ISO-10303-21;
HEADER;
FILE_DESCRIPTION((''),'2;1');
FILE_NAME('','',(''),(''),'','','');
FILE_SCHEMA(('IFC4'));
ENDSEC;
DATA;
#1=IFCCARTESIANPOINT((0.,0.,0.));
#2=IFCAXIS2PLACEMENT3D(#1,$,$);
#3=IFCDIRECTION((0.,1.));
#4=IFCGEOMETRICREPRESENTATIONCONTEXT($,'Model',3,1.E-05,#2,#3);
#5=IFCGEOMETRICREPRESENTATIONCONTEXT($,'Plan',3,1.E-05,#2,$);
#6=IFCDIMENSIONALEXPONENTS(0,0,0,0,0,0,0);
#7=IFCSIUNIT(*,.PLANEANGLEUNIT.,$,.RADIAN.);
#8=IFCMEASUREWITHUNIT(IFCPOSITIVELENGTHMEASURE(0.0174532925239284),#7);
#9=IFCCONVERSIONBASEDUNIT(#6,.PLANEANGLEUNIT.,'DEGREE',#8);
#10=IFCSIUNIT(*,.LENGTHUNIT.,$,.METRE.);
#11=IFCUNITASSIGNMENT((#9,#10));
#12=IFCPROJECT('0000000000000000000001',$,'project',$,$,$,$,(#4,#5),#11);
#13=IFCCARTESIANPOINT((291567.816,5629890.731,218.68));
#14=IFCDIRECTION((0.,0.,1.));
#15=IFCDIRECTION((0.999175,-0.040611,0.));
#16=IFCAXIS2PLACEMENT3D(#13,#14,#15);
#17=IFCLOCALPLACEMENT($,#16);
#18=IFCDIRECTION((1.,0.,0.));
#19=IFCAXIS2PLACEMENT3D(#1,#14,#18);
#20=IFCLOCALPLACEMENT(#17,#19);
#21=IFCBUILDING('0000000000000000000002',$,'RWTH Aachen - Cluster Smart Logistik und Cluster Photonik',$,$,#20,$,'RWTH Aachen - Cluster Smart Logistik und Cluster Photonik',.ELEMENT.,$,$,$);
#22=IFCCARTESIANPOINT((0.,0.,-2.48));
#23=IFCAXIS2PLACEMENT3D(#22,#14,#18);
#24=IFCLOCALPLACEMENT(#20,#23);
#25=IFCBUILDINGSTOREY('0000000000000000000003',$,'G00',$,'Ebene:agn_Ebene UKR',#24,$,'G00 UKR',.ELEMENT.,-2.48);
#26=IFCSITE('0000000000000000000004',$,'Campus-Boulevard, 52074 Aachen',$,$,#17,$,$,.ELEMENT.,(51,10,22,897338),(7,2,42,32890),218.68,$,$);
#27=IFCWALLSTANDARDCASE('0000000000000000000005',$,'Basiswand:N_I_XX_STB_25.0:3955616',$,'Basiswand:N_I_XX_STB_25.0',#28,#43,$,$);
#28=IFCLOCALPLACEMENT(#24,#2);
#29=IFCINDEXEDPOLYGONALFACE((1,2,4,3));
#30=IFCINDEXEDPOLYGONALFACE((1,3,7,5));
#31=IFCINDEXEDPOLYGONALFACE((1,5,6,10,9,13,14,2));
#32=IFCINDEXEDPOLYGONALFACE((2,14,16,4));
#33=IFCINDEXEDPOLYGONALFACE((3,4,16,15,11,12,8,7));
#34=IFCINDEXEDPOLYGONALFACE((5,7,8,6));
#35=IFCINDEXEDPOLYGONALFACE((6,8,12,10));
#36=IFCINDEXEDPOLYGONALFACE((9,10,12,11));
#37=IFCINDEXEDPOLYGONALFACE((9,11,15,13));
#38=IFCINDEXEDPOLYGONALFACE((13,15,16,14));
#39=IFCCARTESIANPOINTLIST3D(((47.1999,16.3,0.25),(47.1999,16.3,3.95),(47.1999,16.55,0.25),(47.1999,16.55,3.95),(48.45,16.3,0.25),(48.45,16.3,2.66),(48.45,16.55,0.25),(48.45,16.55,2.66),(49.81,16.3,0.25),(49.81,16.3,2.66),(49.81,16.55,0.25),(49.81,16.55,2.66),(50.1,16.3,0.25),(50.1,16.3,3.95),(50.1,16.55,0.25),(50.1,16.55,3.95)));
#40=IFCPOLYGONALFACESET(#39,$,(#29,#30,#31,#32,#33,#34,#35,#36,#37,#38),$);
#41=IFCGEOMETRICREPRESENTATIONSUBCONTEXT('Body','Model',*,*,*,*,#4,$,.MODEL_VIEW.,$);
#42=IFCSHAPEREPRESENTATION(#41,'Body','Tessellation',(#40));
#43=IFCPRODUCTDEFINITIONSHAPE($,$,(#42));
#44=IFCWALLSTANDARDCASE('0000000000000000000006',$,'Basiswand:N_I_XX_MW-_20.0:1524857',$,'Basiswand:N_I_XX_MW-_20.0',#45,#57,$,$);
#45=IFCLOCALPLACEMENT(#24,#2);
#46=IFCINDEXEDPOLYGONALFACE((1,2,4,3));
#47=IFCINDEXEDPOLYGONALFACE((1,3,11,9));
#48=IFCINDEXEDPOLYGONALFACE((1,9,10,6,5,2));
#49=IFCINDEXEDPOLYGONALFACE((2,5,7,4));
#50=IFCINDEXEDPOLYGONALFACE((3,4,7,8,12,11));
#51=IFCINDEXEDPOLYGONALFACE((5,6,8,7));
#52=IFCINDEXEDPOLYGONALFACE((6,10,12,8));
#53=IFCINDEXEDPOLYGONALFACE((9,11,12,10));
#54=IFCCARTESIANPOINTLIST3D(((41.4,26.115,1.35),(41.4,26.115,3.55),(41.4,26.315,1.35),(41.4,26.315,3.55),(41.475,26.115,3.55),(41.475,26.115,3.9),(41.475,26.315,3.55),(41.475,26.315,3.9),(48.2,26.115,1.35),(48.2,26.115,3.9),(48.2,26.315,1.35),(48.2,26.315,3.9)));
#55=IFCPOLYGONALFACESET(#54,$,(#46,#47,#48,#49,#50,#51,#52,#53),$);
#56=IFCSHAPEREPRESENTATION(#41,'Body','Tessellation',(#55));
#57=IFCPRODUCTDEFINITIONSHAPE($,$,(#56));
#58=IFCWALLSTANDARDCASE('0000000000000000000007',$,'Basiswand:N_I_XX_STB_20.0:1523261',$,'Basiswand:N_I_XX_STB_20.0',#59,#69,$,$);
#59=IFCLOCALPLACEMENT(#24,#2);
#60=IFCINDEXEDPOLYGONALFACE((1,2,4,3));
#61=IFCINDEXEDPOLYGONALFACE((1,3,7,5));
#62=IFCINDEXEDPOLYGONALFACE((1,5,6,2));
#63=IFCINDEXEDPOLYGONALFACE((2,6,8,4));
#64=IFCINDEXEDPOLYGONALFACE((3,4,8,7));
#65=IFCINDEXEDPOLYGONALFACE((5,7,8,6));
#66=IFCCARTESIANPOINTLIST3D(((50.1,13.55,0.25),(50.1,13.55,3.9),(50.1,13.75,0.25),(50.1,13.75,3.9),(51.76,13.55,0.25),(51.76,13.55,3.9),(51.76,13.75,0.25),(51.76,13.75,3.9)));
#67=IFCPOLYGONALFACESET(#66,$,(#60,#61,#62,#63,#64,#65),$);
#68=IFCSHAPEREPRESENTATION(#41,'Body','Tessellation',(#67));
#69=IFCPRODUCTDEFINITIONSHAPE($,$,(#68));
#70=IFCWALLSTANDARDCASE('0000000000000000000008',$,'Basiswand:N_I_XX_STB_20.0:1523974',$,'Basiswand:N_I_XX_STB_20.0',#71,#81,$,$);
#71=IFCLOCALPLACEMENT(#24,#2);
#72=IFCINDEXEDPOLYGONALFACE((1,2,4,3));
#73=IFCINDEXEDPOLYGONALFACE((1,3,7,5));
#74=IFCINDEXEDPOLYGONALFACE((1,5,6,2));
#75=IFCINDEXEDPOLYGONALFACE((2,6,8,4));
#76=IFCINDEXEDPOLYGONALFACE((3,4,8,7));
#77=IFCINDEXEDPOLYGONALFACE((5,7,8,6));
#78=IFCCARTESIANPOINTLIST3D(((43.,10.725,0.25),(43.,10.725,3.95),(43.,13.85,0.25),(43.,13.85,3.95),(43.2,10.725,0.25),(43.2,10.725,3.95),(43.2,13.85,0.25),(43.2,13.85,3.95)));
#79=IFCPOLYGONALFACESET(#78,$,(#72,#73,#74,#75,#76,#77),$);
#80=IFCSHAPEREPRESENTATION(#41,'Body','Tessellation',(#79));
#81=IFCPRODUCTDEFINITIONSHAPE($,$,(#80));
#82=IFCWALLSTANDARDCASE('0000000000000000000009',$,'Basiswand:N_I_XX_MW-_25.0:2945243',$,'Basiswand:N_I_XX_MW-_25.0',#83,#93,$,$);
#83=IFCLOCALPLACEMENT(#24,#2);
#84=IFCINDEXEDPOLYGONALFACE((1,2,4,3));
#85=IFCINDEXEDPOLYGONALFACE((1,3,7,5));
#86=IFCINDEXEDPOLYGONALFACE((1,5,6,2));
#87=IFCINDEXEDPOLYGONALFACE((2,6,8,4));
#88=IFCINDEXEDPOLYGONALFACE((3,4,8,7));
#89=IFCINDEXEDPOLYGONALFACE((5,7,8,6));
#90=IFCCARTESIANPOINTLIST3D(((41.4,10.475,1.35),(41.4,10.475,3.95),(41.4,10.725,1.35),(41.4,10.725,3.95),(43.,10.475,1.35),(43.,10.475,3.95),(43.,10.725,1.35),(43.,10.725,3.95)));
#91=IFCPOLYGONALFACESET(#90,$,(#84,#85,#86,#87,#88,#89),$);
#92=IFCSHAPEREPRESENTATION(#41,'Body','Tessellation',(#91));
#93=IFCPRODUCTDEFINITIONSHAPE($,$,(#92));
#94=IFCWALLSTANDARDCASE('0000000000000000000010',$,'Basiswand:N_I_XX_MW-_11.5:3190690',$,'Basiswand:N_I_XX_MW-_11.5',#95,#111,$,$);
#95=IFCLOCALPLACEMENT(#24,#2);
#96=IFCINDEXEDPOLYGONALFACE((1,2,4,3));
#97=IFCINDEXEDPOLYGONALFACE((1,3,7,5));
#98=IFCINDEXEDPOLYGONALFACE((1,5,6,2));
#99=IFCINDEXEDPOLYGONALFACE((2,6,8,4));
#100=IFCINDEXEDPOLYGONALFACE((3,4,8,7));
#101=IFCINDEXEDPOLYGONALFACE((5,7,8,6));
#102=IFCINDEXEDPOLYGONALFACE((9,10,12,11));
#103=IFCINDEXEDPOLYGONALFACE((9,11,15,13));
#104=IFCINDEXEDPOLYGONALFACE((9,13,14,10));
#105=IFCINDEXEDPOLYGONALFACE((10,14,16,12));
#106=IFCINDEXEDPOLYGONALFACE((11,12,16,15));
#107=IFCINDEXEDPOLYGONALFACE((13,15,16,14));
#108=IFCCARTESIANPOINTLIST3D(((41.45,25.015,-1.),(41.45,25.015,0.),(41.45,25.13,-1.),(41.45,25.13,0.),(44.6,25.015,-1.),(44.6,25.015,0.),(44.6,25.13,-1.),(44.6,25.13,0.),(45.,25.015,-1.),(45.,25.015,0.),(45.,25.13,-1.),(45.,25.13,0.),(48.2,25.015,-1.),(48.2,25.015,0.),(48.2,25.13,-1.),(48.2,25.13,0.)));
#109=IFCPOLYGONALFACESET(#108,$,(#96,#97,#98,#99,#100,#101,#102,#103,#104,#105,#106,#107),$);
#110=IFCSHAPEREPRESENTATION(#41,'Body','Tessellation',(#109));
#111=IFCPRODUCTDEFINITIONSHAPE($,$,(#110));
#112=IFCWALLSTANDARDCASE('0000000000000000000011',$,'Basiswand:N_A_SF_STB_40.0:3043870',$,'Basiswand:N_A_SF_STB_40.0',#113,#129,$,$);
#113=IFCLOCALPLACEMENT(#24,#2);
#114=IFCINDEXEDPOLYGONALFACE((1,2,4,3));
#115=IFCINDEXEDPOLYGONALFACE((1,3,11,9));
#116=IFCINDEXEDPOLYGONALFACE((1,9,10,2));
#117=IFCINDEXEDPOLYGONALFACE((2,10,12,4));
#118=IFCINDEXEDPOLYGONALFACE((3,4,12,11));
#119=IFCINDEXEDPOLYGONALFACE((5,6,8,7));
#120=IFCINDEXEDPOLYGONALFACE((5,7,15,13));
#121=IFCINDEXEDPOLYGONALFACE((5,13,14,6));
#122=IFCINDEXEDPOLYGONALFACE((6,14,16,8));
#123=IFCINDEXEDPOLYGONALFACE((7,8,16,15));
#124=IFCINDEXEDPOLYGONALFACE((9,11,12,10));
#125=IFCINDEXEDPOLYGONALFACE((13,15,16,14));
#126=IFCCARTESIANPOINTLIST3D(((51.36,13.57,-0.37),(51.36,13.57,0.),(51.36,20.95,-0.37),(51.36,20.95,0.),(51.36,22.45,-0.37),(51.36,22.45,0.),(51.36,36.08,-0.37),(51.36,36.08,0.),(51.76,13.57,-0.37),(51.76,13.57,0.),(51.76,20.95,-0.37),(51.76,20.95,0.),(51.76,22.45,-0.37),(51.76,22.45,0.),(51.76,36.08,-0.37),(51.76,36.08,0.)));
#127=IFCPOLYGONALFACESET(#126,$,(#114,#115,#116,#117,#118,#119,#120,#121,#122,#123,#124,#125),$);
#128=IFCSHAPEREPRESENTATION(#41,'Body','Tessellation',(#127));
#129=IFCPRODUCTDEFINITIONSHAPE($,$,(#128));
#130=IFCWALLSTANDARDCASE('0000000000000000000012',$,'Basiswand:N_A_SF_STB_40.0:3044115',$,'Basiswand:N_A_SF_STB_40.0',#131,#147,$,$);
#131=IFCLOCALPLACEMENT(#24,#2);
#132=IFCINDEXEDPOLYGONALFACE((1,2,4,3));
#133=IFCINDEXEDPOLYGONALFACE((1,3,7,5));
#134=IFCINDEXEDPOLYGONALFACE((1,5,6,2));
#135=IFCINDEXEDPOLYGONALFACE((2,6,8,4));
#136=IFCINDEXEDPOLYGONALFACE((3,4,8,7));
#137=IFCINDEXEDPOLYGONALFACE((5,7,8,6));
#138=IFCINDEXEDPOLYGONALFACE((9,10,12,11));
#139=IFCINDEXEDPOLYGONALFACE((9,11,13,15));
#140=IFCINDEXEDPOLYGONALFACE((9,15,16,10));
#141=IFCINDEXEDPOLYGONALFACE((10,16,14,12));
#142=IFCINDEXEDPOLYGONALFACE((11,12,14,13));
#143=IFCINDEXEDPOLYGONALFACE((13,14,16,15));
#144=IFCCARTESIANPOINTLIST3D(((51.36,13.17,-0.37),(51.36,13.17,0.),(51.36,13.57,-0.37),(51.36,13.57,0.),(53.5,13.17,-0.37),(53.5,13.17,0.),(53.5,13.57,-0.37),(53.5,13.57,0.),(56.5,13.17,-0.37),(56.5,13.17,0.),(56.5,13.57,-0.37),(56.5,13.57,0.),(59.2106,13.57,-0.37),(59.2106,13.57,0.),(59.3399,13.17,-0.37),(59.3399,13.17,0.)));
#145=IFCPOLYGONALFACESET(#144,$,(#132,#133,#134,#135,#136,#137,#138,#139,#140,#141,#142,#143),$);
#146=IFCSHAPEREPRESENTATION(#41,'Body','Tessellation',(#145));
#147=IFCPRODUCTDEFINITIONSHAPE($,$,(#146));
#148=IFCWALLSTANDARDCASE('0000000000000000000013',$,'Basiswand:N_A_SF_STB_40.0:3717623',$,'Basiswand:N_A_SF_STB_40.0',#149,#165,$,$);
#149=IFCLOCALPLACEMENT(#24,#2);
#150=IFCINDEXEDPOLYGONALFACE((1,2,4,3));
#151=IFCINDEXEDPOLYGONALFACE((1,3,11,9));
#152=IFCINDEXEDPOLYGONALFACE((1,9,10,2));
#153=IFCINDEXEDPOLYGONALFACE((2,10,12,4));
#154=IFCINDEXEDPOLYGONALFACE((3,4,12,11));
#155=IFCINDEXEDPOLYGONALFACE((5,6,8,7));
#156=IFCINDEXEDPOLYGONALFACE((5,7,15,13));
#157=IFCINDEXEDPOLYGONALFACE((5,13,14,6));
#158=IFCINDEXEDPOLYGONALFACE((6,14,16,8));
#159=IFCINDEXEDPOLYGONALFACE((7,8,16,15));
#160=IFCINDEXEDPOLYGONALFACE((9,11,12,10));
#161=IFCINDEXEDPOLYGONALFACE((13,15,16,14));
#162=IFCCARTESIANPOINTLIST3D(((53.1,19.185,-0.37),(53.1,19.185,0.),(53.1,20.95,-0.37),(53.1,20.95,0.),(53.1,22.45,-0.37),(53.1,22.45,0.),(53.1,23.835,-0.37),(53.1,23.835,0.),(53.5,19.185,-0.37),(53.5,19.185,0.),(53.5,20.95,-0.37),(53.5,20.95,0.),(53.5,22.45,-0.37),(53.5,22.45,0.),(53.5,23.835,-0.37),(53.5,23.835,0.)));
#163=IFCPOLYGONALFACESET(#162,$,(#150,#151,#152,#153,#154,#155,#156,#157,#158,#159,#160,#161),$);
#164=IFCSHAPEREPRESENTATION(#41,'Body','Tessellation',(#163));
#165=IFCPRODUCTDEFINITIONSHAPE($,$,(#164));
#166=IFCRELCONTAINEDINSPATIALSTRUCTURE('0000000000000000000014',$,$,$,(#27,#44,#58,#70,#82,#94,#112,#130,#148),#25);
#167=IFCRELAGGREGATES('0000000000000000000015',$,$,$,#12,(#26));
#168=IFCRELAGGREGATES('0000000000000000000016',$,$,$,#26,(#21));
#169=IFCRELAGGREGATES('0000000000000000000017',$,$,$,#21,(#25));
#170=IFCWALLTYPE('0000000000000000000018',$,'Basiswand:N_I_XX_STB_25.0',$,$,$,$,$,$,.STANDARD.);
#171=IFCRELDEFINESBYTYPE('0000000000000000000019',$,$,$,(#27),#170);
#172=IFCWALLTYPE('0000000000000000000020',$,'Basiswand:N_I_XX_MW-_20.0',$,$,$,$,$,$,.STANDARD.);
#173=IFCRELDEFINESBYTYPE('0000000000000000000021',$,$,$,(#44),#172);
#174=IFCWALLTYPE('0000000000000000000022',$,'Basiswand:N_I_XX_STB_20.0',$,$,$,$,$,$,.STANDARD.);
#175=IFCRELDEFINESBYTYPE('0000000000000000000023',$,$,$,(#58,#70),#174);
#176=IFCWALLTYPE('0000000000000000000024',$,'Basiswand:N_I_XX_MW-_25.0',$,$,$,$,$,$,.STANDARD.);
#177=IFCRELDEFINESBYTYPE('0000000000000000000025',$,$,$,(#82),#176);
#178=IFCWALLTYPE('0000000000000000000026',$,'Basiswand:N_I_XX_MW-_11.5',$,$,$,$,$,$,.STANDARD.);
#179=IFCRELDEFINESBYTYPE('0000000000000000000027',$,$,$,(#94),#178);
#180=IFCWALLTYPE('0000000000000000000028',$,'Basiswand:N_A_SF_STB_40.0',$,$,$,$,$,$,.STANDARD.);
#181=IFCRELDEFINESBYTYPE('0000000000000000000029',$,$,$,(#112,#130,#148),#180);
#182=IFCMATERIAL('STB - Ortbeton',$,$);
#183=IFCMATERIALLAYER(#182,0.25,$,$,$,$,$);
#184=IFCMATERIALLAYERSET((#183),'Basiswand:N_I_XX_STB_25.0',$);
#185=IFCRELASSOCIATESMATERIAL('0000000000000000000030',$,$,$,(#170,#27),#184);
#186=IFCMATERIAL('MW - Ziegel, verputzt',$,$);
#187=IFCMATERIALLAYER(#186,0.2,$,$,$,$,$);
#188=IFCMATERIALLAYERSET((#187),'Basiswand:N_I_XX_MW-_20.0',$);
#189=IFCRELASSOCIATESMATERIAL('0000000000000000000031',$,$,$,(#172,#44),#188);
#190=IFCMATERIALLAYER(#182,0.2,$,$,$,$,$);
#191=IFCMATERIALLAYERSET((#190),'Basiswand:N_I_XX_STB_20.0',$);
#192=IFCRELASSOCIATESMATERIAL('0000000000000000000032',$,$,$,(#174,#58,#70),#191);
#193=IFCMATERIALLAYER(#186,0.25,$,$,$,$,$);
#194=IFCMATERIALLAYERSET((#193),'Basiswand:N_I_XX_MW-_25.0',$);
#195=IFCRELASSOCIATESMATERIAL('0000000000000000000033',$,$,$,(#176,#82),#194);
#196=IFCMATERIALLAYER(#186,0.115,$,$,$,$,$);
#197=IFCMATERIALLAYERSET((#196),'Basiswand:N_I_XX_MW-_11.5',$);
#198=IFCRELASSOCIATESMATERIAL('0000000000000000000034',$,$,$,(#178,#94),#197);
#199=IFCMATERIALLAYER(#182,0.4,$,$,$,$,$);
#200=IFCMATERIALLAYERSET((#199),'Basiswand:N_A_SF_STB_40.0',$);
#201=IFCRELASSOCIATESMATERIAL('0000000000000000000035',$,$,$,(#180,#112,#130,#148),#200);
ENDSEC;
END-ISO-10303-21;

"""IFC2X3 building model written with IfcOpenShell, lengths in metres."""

from ifc_helpers import new_model, entity, si_unit, converted_unit, direction, frame, frame_2d, origin, origin_with_axes, origin_2d_with_axis, place, context, subcontext, project, spatial, polyline, rectangle, extrude, clip, bounded_halfspace, material, layer, layer_set, layer_usage, type_object, element, save


model = new_model("IFC2X3")

# Units and contexts
model_context = context("Model", 3, precision=1e-05, world=origin(), true_north=direction((0.0, 1.0)))
plan_context = context("Plan", 3, precision=1e-05, world=origin())
body_context = subcontext(model_context, "Body", "Model", "MODEL_VIEW")
ifc_project = project(units=[converted_unit("PLANEANGLEUNIT", "DEGREE", entity("IfcPositiveLengthMeasure", 0.0174532925239284), si_unit("PLANEANGLEUNIT", "RADIAN"), dimensions=[0, 0, 0, 0, 0, 0, 0]), si_unit("LENGTHUNIT", "METRE")], contexts=[model_context, plan_context])

# Site, building, storey
site_placement = place(None, frame((291567.816, 5629890.731, 218.68), z_axis=(0.0, 0.0, 1.0), x_axis=(0.999175, -0.040611, 0.0)))
site = spatial("IfcSite", under=ifc_project, at=site_placement, Name="Campus-Boulevard, 52074 Aachen", CompositionType="ELEMENT", RefLatitude=(51, 10, 22, 897338), RefLongitude=(7, 2, 42, 32890), RefElevation=218.68)
building_placement = place(site_placement, origin_with_axes())
building = spatial("IfcBuilding", under=site, at=building_placement, Name="RWTH Aachen - Cluster Smart Logistik und Cluster Photonik", LongName="RWTH Aachen - Cluster Smart Logistik und Cluster Photonik", CompositionType="ELEMENT")
storey_placement = place(building_placement, frame((0.0, 0.0, -2.48), z_axis=(0.0, 0.0, 1.0), x_axis=(1.0, 0.0, 0.0)))
storey = spatial("IfcBuildingStorey", under=building, at=storey_placement, Name="G00", ObjectType="Ebene:agn_Ebene UKR", LongName="G00 UKR", CompositionType="ELEMENT", Elevation=-2.48)

# Shared definitions
ifc_material_1 = material(Name="STB - Ortbeton")

# Shared definitions
ifc_layer_1 = layer(ifc_material_1, 0.25)
ifc_layer_set_1 = layer_set([ifc_layer_1], Name="Basiswand:N_I_XX_STB_25.0")
wall_type_1 = type_object("IfcWallType", Name="Basiswand:N_I_XX_STB_25.0", PredefinedType="STANDARD", material=ifc_layer_set_1)

# Wall, opening
ifc_layer_usage_1 = layer_usage(ifc_layer_set_1, "AXIS2", "NEGATIVE", 0.125)
wall_1_placement = place(storey_placement, frame((50.1, 16.425, 0.25), z_axis=(0.0, 0.0, 1.0), x_axis=(-1.0, 0.0, 0.0)))
wall_1 = element("IfcWallStandardCase", 1, at=wall_1_placement, inside=storey, type_object=wall_type_1, material=ifc_layer_usage_1, Name="Basiswand:N_I_XX_STB_25.0:3955616", ObjectType="Basiswand:N_I_XX_STB_25.0", context=body_context, shape_type="SweptSolid", body=[
    extrude(rectangle(XDim=2.9002, YDim=0.25, at=frame_2d((1.4501, 0.0), x_axis=(-1.0, 0.0))), origin(), (0.0, 0.0, 1.0), 3.7),
])
opening_1_placement = place(wall_1_placement, frame((0.29, -0.125, 0.0), z_axis=(0.0, 0.0, 1.0), x_axis=(1.0, 0.0, 0.0)))
element("IfcOpeningElement", 2, at=opening_1_placement, cuts=wall_1, ObjectType="Opening", context=body_context, shape_type="SweptSolid", body=[
    extrude(rectangle(XDim=2.41, YDim=1.36, at=frame_2d((1.205, 0.68), x_axis=(1.0, 0.0))), frame((0.0, 0.0, 0.0), z_axis=(0.0, 1.0, 0.0), x_axis=(0.0, 0.0, 1.0)), (0.0, 0.0, 1.0), 0.25),
])

# Walls
ifc_material_2 = material(Name="MW - Ziegel, verputzt")
ifc_layer_2 = layer(ifc_material_2, 0.2)
ifc_layer_set_2 = layer_set([ifc_layer_2], Name="Basiswand:N_I_XX_MW-_20.0")
ifc_layer_usage_2 = layer_usage(ifc_layer_set_2, "AXIS2", "NEGATIVE", 0.1)
wall_type_2 = type_object("IfcWallType", Name="Basiswand:N_I_XX_MW-_20.0", PredefinedType="STANDARD", material=ifc_layer_set_2)
wall_2_placement = place(storey_placement, frame((41.4, 26.215, 1.35), z_axis=(0.0, 0.0, 1.0), x_axis=(1.0, 0.0, 0.0)))
element("IfcWallStandardCase", 3, at=wall_2_placement, inside=storey, type_object=wall_type_2, material=ifc_layer_usage_2, Name="Basiswand:N_I_XX_MW-_20.0:1524857", ObjectType="Basiswand:N_I_XX_MW-_20.0", context=body_context, shape_type="Clipping", body=[
    clip(clip(extrude(rectangle(XDim=6.8, YDim=0.2, at=frame_2d((3.4, 0.0), x_axis=(-1.0, 0.0))), origin(), (0.0, 0.0, 1.0), 2.55), bounded_halfspace(frame((0.075, 0.1, 2.2), z_axis=(-1.0, 0.0, 0.0), x_axis=(0.0, 0.0, -1.0)), False, frame((0.075, 0.1, 2.2), z_axis=(-1.0, 0.0, 0.0), x_axis=(0.0, 0.0, -1.0)), polyline([(0.0, 0.0), (0.0, 0.2), (-0.35, 0.2), (-0.35, 0.0), (0.0, 0.0)]))), bounded_halfspace(frame((0.075, -0.1, 2.2), z_axis=(0.0, 0.0, 1.0), x_axis=(-1.0, 0.0, 0.0)), False, frame((0.075, -0.1, 2.2), z_axis=(0.0, 0.0, 1.0), x_axis=(-1.0, 0.0, 0.0)), polyline([(0.0, 0.0), (0.0, -0.2), (0.075, -0.2), (0.075, 0.0), (0.0, 0.0)]))),
])
ifc_layer_3 = layer(ifc_material_1, 0.2)
ifc_layer_set_3 = layer_set([ifc_layer_3], Name="Basiswand:N_I_XX_STB_20.0")
ifc_layer_usage_3 = layer_usage(ifc_layer_set_3, "AXIS2", "NEGATIVE", 0.1)
wall_type_3 = type_object("IfcWallType", Name="Basiswand:N_I_XX_STB_20.0", PredefinedType="STANDARD", material=ifc_layer_set_3)
wall_3_placement = place(storey_placement, frame((51.76, 13.65, 0.25), z_axis=(0.0, 0.0, 1.0), x_axis=(-1.0, 0.0, 0.0)))
element("IfcWallStandardCase", 4, at=wall_3_placement, inside=storey, type_object=wall_type_3, material=ifc_layer_usage_3, Name="Basiswand:N_I_XX_STB_20.0:1523261", ObjectType="Basiswand:N_I_XX_STB_20.0", context=body_context, shape_type="SweptSolid", body=[
    extrude(rectangle(XDim=1.66, YDim=0.2, at=frame_2d((0.83, 0.0), x_axis=(-1.0, 0.0))), origin(), (0.0, 0.0, 1.0), 3.65),
])
ifc_layer_usage_4 = layer_usage(ifc_layer_set_3, "AXIS2", "NEGATIVE", 0.1)
wall_4_placement = place(storey_placement, frame((43.1, 13.85, 0.25), z_axis=(0.0, 0.0, 1.0), x_axis=(0.0, -1.0, 0.0)))
element("IfcWallStandardCase", 5, at=wall_4_placement, inside=storey, type_object=wall_type_3, material=ifc_layer_usage_4, Name="Basiswand:N_I_XX_STB_20.0:1523974", ObjectType="Basiswand:N_I_XX_STB_20.0", context=body_context, shape_type="SweptSolid", body=[
    extrude(rectangle(XDim=3.125, YDim=0.2, at=frame_2d((1.5625, 0.0), x_axis=(-1.0, 0.0))), origin(), (0.0, 0.0, 1.0), 3.7),
])
ifc_layer_4 = layer(ifc_material_2, 0.25)
ifc_layer_set_4 = layer_set([ifc_layer_4], Name="Basiswand:N_I_XX_MW-_25.0")
ifc_layer_usage_5 = layer_usage(ifc_layer_set_4, "AXIS2", "NEGATIVE", 0.125)
wall_type_4 = type_object("IfcWallType", Name="Basiswand:N_I_XX_MW-_25.0", PredefinedType="STANDARD", material=ifc_layer_set_4)
wall_5_placement = place(storey_placement, frame((43.0, 10.6, 1.35), z_axis=(0.0, 0.0, 1.0), x_axis=(-1.0, 0.0, 0.0)))
element("IfcWallStandardCase", 6, at=wall_5_placement, inside=storey, type_object=wall_type_4, material=ifc_layer_usage_5, Name="Basiswand:N_I_XX_MW-_25.0:2945243", ObjectType="Basiswand:N_I_XX_MW-_25.0", context=body_context, shape_type="SweptSolid", body=[
    extrude(rectangle(XDim=1.6, YDim=0.25, at=frame_2d((0.8, 0.0), x_axis=(-1.0, 0.0))), origin(), (0.0, 0.0, 1.0), 2.6),
])

# Walls, openings
ifc_layer_5 = layer(ifc_material_2, 0.115)
ifc_layer_set_5 = layer_set([ifc_layer_5], Name="Basiswand:N_I_XX_MW-_11.5")
ifc_layer_usage_6 = layer_usage(ifc_layer_set_5, "AXIS2", "NEGATIVE", 0.0575)
wall_type_5 = type_object("IfcWallType", Name="Basiswand:N_I_XX_MW-_11.5", PredefinedType="STANDARD", material=ifc_layer_set_5)
wall_6_placement = place(storey_placement, frame((48.2, 25.0725, -1.0), z_axis=(0.0, 0.0, 1.0), x_axis=(-1.0, 0.0, 0.0)))
wall_6 = element("IfcWallStandardCase", 7, at=wall_6_placement, inside=storey, type_object=wall_type_5, material=ifc_layer_usage_6, Name="Basiswand:N_I_XX_MW-_11.5:3190690", ObjectType="Basiswand:N_I_XX_MW-_11.5", context=body_context, shape_type="SweptSolid", body=[
    extrude(rectangle(XDim=6.75, YDim=0.115, at=frame_2d((3.375, 0.0), x_axis=(-1.0, 0.0))), origin(), (0.0, 0.0, 1.0), 1.0),
])
opening_2_placement = place(wall_6_placement, origin_with_axes())
element("IfcOpeningElement", 8, at=opening_2_placement, cuts=wall_6, ObjectType="Opening", context=body_context, shape_type="SweptSolid", body=[
    extrude(rectangle(XDim=1.0, YDim=0.115, at=origin_2d_with_axis()), frame((3.6, 0.0, 0.5), z_axis=(-1.0, 0.0, 0.0), x_axis=(0.0, 0.0, 1.0)), (0.0, 0.0, 1.0), 0.4),
])
ifc_layer_6 = layer(ifc_material_1, 0.4)
ifc_layer_set_6 = layer_set([ifc_layer_6], Name="Basiswand:N_A_SF_STB_40.0")
ifc_layer_usage_7 = layer_usage(ifc_layer_set_6, "AXIS2", "POSITIVE", -0.2)
wall_type_6 = type_object("IfcWallType", Name="Basiswand:N_A_SF_STB_40.0", PredefinedType="STANDARD", material=ifc_layer_set_6)
wall_7_placement = place(storey_placement, frame((51.56, 13.57, -0.37), z_axis=(0.0, 0.0, 1.0), x_axis=(0.0, 1.0, 0.0)))
wall_7 = element("IfcWallStandardCase", 9, at=wall_7_placement, inside=storey, type_object=wall_type_6, material=ifc_layer_usage_7, Name="Basiswand:N_A_SF_STB_40.0:3043870", ObjectType="Basiswand:N_A_SF_STB_40.0", context=body_context, shape_type="SweptSolid", body=[
    extrude(rectangle(XDim=22.51, YDim=0.4, at=frame_2d((11.255, 0.0), x_axis=(-1.0, 0.0))), origin(), (0.0, 0.0, 1.0), 0.37),
])
opening_3_placement = place(wall_7_placement, origin_with_axes())
element("IfcOpeningElement", 10, at=opening_3_placement, cuts=wall_7, ObjectType="Opening", context=body_context, shape_type="SweptSolid", body=[
    extrude(rectangle(XDim=0.37, YDim=0.4, at=frame_2d((0.005, -0.04), x_axis=(1.0, 0.0))), frame((7.38, 0.04, 0.19), z_axis=(1.0, 0.0, 0.0), x_axis=(0.0, 0.0, -1.0)), (0.0, 0.0, 1.0), 1.5),
])
ifc_layer_usage_8 = layer_usage(ifc_layer_set_6, "AXIS2", "POSITIVE", -0.2)
wall_8_placement = place(storey_placement, frame((59.3399, 13.37, -0.37), z_axis=(0.0, 0.0, 1.0), x_axis=(-1.0, 0.0, 0.0)))
wall_8 = element("IfcWallStandardCase", 11, at=wall_8_placement, inside=storey, type_object=wall_type_6, material=ifc_layer_usage_8, Name="Basiswand:N_A_SF_STB_40.0:3044115", ObjectType="Basiswand:N_A_SF_STB_40.0", context=body_context, shape_type="Clipping", body=[
    clip(extrude(rectangle(XDim=7.9799, YDim=0.4, at=frame_2d((3.9899, 0.0), x_axis=(-1.0, 0.0))), origin(), (0.0, 0.0, 1.0), 0.37), bounded_halfspace(frame((0.1293, -0.2, 0.37), z_axis=(0.95152, 0.307586, 0.0), x_axis=(0.0, 0.0, -1.0)), True, frame((0.1293, -0.2, 0.37), z_axis=(0.95152, 0.307586, 0.0), x_axis=(0.0, 0.0, -1.0)), polyline([(0.0, 0.0), (0.37, 0.0), (0.37, 0.4204), (0.16, 0.4204), (0.0, 0.4204), (0.0, 0.0)]))),
])
opening_4_placement = place(wall_8_placement, origin_with_axes())
element("IfcOpeningElement", 12, at=opening_4_placement, cuts=wall_8, ObjectType="Opening", context=body_context, shape_type="SweptSolid", body=[
    extrude(rectangle(XDim=0.37, YDim=0.4, at=frame_2d((0.0017, 0.0), x_axis=(1.0, 0.0))), frame((5.8399, 0.0, 0.1833), z_axis=(-1.0, 0.0, 0.0), x_axis=(0.0, 0.0, 1.0)), (0.0, 0.0, 1.0), 3.0),
])
ifc_layer_usage_9 = layer_usage(ifc_layer_set_6, "AXIS2", "NEGATIVE", 0.2)
wall_9_placement = place(storey_placement, frame((53.3, 19.185, -0.37), z_axis=(0.0, 0.0, 1.0), x_axis=(0.0, 1.0, 0.0)))
wall_9 = element("IfcWallStandardCase", 13, at=wall_9_placement, inside=storey, type_object=wall_type_6, material=ifc_layer_usage_9, Name="Basiswand:N_A_SF_STB_40.0:3717623", ObjectType="Basiswand:N_A_SF_STB_40.0", context=body_context, shape_type="SweptSolid", body=[
    extrude(rectangle(XDim=4.65, YDim=0.4, at=frame_2d((2.325, 0.0), x_axis=(-1.0, 0.0))), origin(), (0.0, 0.0, 1.0), 0.37),
])
opening_5_placement = place(wall_9_placement, origin_with_axes())
element("IfcOpeningElement", 14, at=opening_5_placement, cuts=wall_9, ObjectType="Opening", context=body_context, shape_type="SweptSolid", body=[
    extrude(rectangle(XDim=0.37, YDim=0.4, at=origin_2d_with_axis()), frame((1.765, 0.0, 0.185), z_axis=(1.0, 0.0, 0.0), x_axis=(0.0, 0.0, -1.0)), (0.0, 0.0, 1.0), 1.5),
])

save(model, "model.ifc")
